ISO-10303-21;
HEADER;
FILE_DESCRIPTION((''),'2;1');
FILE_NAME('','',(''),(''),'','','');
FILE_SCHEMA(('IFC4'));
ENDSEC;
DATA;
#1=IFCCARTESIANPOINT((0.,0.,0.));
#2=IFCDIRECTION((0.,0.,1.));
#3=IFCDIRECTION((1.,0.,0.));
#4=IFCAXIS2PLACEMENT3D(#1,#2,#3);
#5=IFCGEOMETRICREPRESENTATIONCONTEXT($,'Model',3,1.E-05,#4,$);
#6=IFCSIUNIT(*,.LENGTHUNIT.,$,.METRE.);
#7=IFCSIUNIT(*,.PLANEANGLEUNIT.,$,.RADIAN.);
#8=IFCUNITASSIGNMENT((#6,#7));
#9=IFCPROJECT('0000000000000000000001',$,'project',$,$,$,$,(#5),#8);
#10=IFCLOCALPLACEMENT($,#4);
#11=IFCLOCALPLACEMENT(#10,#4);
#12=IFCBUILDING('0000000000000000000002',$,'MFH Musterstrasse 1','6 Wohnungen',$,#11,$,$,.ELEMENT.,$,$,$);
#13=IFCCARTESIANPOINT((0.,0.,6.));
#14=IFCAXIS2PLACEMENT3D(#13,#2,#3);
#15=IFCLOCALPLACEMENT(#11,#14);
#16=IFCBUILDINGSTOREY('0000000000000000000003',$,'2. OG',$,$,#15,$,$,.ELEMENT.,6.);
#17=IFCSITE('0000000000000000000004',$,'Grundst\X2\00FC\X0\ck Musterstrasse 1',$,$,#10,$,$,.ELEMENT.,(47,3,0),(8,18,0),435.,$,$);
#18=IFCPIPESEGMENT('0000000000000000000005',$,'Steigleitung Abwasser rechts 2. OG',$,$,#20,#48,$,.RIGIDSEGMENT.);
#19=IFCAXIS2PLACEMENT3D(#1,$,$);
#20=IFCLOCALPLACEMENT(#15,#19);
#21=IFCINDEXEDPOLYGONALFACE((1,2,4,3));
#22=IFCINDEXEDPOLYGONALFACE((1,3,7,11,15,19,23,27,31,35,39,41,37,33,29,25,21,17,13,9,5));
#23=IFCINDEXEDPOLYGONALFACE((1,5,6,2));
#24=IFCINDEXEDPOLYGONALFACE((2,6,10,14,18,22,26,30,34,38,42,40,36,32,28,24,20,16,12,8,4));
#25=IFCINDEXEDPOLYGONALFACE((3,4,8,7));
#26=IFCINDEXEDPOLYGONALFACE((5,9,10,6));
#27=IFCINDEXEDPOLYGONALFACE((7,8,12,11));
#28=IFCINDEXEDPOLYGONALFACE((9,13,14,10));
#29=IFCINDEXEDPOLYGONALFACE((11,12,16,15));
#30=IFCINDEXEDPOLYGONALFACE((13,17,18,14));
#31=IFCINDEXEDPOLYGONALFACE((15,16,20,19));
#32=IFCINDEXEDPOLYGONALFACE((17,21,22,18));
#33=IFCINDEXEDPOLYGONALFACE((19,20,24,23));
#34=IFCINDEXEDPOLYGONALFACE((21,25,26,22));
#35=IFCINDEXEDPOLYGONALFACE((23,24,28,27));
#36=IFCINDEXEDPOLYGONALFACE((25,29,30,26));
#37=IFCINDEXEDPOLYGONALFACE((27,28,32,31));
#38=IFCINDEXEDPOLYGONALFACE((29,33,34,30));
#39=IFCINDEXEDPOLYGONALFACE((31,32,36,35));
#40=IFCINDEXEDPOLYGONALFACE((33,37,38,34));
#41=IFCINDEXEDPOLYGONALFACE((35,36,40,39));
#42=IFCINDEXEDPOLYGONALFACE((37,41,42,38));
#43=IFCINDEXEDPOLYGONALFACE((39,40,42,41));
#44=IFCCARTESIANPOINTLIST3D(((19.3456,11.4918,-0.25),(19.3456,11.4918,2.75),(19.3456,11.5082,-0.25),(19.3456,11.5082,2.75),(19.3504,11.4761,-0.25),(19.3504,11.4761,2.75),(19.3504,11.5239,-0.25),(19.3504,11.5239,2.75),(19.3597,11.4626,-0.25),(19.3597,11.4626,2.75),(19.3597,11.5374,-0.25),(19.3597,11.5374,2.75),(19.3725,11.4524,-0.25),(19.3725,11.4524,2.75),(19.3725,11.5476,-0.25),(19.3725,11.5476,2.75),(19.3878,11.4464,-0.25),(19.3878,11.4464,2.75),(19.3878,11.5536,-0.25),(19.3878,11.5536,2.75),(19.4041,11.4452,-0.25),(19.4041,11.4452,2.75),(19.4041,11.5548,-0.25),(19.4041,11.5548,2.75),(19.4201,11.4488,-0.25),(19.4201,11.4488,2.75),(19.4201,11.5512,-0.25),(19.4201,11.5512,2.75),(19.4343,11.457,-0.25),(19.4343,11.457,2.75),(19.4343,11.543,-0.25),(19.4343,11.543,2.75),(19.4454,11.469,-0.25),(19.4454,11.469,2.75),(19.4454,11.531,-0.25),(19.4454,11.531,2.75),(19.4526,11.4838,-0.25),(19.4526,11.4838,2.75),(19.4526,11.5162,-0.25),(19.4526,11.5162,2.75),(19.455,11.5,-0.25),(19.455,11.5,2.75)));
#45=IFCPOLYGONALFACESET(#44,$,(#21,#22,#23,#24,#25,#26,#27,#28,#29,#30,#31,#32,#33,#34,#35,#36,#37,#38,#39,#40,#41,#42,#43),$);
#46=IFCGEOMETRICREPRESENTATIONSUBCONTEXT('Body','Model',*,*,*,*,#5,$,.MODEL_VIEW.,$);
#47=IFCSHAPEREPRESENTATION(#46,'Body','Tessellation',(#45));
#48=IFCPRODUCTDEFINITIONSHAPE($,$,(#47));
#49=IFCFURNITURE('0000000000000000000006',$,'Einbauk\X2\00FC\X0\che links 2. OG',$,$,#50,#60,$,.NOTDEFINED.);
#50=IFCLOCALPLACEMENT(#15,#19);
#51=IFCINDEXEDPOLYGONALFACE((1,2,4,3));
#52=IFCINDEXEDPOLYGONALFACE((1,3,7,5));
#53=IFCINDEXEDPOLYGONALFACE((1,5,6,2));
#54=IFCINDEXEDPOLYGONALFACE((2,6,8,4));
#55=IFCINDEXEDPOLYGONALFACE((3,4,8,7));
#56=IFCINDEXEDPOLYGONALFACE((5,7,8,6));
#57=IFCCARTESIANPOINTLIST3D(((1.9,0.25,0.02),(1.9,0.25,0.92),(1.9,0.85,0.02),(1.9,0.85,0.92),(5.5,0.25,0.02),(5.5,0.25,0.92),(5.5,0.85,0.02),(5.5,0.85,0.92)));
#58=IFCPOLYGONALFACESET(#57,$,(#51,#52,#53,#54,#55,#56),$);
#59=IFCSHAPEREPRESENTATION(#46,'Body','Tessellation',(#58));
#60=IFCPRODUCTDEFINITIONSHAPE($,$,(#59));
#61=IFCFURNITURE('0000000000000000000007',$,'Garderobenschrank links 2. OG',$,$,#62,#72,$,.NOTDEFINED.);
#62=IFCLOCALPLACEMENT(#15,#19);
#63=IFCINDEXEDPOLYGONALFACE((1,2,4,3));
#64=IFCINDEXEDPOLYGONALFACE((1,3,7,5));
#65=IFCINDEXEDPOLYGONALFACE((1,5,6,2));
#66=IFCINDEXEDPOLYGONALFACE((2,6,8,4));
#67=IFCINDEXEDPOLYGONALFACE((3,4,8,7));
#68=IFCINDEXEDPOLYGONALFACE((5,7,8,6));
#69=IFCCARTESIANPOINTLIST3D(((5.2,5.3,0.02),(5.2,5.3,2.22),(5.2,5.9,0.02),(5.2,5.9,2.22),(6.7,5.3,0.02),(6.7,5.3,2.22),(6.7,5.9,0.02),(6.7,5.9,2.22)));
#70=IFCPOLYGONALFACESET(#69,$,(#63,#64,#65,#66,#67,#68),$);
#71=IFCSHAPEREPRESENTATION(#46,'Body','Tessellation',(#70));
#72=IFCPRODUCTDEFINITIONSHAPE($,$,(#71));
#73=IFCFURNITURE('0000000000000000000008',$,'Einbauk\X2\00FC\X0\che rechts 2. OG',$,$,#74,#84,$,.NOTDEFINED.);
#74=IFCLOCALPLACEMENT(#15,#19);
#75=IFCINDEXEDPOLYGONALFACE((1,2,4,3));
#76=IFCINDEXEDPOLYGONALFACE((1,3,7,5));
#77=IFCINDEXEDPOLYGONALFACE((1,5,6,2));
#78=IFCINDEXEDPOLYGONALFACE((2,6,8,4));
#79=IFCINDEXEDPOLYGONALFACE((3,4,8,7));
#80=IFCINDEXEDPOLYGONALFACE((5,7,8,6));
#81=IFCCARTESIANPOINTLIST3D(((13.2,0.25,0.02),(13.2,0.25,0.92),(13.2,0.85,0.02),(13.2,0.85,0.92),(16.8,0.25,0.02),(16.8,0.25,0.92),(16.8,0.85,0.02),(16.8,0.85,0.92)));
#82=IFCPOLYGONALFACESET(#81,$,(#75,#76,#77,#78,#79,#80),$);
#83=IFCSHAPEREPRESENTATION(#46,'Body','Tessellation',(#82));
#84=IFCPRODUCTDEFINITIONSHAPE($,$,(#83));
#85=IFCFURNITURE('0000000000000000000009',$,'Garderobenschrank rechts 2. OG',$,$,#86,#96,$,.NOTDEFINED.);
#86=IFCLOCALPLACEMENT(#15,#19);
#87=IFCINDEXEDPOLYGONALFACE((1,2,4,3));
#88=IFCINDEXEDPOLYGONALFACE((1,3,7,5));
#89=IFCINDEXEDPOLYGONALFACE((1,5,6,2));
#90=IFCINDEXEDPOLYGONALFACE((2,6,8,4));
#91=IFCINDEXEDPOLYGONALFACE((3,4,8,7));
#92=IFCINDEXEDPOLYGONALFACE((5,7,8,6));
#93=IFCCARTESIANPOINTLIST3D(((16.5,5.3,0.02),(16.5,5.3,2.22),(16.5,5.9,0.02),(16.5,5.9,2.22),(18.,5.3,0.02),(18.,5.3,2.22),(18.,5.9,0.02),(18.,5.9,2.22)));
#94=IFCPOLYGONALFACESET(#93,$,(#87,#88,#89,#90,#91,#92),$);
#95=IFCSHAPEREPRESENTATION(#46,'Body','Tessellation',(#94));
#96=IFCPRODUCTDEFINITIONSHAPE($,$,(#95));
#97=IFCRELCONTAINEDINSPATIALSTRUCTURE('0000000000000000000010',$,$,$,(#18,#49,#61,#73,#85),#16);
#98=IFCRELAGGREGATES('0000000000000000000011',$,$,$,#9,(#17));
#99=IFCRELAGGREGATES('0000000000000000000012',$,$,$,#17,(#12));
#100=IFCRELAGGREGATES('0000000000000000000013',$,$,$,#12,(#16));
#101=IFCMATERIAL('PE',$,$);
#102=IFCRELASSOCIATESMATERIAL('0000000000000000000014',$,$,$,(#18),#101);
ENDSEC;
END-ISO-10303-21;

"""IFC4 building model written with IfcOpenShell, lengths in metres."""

from ifc_helpers import new_model, si_unit, frame, frame_2d, origin_with_axes, origin_2d_with_axis, place, context, subcontext, project, spatial, rectangle, circle, extrude, material, element, save


model = new_model("IFC4")

# Units and contexts
model_context = context("Model", 3, precision=1e-05, world=origin_with_axes())
body_context = subcontext(model_context, "Body", "Model", "MODEL_VIEW")
ifc_project = project(units=[si_unit("LENGTHUNIT", "METRE"), si_unit("PLANEANGLEUNIT", "RADIAN")], contexts=[model_context])

# Site, building, storey
site_placement = place(None, origin_with_axes())
site = spatial("IfcSite", under=ifc_project, at=site_placement, Name="Grundstück Musterstrasse 1", CompositionType="ELEMENT", RefLatitude=(47, 3, 0), RefLongitude=(8, 18, 0), RefElevation=435.0)
building_placement = place(site_placement, origin_with_axes())
building = spatial("IfcBuilding", under=site, at=building_placement, Name="MFH Musterstrasse 1", Description="6 Wohnungen", CompositionType="ELEMENT")
storey_placement = place(building_placement, frame((0.0, 0.0, 6.0), z_axis=(0.0, 0.0, 1.0), x_axis=(1.0, 0.0, 0.0)))
storey = spatial("IfcBuildingStorey", under=building, at=storey_placement, Name="2. OG", CompositionType="ELEMENT", Elevation=6.0)

# Shared definitions
ifc_material_1 = material(Name="PE")

# Pipe segment
pipe_segment_1_placement = place(storey_placement, origin_with_axes())
element("IfcPipeSegment", 1, at=pipe_segment_1_placement, inside=storey, material=ifc_material_1, Name="Steigleitung Abwasser rechts 2. OG", PredefinedType="RIGIDSEGMENT", context=body_context, shape_type="SweptSolid", body=[
    extrude(circle(Radius=0.055, at=origin_2d_with_axis()), frame((19.4, 11.5, -0.25), z_axis=(0.0, 0.0, 1.0), x_axis=(1.0, 0.0, 0.0)), (0.0, 0.0, 1.0), 3.0),
])

# Furniture
furniture_1_placement = place(storey_placement, origin_with_axes())
element("IfcFurniture", 2, at=furniture_1_placement, inside=storey, Name="Einbauküche links 2. OG", PredefinedType="NOTDEFINED", context=body_context, shape_type="SweptSolid", body=[
    extrude(rectangle(XDim=3.6, YDim=0.6, at=frame_2d((1.8, 0.3), x_axis=(1.0, 0.0))), frame((1.9, 0.25, 0.02), z_axis=(0.0, 0.0, 1.0), x_axis=(1.0, 0.0, 0.0)), (0.0, 0.0, 1.0), 0.9),
])
furniture_2_placement = place(storey_placement, origin_with_axes())
element("IfcFurniture", 3, at=furniture_2_placement, inside=storey, Name="Garderobenschrank links 2. OG", PredefinedType="NOTDEFINED", context=body_context, shape_type="SweptSolid", body=[
    extrude(rectangle(XDim=1.5, YDim=0.6, at=frame_2d((0.75, 0.3), x_axis=(1.0, 0.0))), frame((5.2, 5.3, 0.02), z_axis=(0.0, 0.0, 1.0), x_axis=(1.0, 0.0, 0.0)), (0.0, 0.0, 1.0), 2.2),
])
furniture_3_placement = place(storey_placement, origin_with_axes())
element("IfcFurniture", 4, at=furniture_3_placement, inside=storey, Name="Einbauküche rechts 2. OG", PredefinedType="NOTDEFINED", context=body_context, shape_type="SweptSolid", body=[
    extrude(rectangle(XDim=3.6, YDim=0.6, at=frame_2d((1.8, 0.3), x_axis=(1.0, 0.0))), frame((13.2, 0.25, 0.02), z_axis=(0.0, 0.0, 1.0), x_axis=(1.0, 0.0, 0.0)), (0.0, 0.0, 1.0), 0.9),
])
furniture_4_placement = place(storey_placement, origin_with_axes())
element("IfcFurniture", 5, at=furniture_4_placement, inside=storey, Name="Garderobenschrank rechts 2. OG", PredefinedType="NOTDEFINED", context=body_context, shape_type="SweptSolid", body=[
    extrude(rectangle(XDim=1.5, YDim=0.6, at=frame_2d((0.75, 0.3), x_axis=(1.0, 0.0))), frame((16.5, 5.3, 0.02), z_axis=(0.0, 0.0, 1.0), x_axis=(1.0, 0.0, 0.0)), (0.0, 0.0, 1.0), 2.2),
])

save(model, "model.ifc")
